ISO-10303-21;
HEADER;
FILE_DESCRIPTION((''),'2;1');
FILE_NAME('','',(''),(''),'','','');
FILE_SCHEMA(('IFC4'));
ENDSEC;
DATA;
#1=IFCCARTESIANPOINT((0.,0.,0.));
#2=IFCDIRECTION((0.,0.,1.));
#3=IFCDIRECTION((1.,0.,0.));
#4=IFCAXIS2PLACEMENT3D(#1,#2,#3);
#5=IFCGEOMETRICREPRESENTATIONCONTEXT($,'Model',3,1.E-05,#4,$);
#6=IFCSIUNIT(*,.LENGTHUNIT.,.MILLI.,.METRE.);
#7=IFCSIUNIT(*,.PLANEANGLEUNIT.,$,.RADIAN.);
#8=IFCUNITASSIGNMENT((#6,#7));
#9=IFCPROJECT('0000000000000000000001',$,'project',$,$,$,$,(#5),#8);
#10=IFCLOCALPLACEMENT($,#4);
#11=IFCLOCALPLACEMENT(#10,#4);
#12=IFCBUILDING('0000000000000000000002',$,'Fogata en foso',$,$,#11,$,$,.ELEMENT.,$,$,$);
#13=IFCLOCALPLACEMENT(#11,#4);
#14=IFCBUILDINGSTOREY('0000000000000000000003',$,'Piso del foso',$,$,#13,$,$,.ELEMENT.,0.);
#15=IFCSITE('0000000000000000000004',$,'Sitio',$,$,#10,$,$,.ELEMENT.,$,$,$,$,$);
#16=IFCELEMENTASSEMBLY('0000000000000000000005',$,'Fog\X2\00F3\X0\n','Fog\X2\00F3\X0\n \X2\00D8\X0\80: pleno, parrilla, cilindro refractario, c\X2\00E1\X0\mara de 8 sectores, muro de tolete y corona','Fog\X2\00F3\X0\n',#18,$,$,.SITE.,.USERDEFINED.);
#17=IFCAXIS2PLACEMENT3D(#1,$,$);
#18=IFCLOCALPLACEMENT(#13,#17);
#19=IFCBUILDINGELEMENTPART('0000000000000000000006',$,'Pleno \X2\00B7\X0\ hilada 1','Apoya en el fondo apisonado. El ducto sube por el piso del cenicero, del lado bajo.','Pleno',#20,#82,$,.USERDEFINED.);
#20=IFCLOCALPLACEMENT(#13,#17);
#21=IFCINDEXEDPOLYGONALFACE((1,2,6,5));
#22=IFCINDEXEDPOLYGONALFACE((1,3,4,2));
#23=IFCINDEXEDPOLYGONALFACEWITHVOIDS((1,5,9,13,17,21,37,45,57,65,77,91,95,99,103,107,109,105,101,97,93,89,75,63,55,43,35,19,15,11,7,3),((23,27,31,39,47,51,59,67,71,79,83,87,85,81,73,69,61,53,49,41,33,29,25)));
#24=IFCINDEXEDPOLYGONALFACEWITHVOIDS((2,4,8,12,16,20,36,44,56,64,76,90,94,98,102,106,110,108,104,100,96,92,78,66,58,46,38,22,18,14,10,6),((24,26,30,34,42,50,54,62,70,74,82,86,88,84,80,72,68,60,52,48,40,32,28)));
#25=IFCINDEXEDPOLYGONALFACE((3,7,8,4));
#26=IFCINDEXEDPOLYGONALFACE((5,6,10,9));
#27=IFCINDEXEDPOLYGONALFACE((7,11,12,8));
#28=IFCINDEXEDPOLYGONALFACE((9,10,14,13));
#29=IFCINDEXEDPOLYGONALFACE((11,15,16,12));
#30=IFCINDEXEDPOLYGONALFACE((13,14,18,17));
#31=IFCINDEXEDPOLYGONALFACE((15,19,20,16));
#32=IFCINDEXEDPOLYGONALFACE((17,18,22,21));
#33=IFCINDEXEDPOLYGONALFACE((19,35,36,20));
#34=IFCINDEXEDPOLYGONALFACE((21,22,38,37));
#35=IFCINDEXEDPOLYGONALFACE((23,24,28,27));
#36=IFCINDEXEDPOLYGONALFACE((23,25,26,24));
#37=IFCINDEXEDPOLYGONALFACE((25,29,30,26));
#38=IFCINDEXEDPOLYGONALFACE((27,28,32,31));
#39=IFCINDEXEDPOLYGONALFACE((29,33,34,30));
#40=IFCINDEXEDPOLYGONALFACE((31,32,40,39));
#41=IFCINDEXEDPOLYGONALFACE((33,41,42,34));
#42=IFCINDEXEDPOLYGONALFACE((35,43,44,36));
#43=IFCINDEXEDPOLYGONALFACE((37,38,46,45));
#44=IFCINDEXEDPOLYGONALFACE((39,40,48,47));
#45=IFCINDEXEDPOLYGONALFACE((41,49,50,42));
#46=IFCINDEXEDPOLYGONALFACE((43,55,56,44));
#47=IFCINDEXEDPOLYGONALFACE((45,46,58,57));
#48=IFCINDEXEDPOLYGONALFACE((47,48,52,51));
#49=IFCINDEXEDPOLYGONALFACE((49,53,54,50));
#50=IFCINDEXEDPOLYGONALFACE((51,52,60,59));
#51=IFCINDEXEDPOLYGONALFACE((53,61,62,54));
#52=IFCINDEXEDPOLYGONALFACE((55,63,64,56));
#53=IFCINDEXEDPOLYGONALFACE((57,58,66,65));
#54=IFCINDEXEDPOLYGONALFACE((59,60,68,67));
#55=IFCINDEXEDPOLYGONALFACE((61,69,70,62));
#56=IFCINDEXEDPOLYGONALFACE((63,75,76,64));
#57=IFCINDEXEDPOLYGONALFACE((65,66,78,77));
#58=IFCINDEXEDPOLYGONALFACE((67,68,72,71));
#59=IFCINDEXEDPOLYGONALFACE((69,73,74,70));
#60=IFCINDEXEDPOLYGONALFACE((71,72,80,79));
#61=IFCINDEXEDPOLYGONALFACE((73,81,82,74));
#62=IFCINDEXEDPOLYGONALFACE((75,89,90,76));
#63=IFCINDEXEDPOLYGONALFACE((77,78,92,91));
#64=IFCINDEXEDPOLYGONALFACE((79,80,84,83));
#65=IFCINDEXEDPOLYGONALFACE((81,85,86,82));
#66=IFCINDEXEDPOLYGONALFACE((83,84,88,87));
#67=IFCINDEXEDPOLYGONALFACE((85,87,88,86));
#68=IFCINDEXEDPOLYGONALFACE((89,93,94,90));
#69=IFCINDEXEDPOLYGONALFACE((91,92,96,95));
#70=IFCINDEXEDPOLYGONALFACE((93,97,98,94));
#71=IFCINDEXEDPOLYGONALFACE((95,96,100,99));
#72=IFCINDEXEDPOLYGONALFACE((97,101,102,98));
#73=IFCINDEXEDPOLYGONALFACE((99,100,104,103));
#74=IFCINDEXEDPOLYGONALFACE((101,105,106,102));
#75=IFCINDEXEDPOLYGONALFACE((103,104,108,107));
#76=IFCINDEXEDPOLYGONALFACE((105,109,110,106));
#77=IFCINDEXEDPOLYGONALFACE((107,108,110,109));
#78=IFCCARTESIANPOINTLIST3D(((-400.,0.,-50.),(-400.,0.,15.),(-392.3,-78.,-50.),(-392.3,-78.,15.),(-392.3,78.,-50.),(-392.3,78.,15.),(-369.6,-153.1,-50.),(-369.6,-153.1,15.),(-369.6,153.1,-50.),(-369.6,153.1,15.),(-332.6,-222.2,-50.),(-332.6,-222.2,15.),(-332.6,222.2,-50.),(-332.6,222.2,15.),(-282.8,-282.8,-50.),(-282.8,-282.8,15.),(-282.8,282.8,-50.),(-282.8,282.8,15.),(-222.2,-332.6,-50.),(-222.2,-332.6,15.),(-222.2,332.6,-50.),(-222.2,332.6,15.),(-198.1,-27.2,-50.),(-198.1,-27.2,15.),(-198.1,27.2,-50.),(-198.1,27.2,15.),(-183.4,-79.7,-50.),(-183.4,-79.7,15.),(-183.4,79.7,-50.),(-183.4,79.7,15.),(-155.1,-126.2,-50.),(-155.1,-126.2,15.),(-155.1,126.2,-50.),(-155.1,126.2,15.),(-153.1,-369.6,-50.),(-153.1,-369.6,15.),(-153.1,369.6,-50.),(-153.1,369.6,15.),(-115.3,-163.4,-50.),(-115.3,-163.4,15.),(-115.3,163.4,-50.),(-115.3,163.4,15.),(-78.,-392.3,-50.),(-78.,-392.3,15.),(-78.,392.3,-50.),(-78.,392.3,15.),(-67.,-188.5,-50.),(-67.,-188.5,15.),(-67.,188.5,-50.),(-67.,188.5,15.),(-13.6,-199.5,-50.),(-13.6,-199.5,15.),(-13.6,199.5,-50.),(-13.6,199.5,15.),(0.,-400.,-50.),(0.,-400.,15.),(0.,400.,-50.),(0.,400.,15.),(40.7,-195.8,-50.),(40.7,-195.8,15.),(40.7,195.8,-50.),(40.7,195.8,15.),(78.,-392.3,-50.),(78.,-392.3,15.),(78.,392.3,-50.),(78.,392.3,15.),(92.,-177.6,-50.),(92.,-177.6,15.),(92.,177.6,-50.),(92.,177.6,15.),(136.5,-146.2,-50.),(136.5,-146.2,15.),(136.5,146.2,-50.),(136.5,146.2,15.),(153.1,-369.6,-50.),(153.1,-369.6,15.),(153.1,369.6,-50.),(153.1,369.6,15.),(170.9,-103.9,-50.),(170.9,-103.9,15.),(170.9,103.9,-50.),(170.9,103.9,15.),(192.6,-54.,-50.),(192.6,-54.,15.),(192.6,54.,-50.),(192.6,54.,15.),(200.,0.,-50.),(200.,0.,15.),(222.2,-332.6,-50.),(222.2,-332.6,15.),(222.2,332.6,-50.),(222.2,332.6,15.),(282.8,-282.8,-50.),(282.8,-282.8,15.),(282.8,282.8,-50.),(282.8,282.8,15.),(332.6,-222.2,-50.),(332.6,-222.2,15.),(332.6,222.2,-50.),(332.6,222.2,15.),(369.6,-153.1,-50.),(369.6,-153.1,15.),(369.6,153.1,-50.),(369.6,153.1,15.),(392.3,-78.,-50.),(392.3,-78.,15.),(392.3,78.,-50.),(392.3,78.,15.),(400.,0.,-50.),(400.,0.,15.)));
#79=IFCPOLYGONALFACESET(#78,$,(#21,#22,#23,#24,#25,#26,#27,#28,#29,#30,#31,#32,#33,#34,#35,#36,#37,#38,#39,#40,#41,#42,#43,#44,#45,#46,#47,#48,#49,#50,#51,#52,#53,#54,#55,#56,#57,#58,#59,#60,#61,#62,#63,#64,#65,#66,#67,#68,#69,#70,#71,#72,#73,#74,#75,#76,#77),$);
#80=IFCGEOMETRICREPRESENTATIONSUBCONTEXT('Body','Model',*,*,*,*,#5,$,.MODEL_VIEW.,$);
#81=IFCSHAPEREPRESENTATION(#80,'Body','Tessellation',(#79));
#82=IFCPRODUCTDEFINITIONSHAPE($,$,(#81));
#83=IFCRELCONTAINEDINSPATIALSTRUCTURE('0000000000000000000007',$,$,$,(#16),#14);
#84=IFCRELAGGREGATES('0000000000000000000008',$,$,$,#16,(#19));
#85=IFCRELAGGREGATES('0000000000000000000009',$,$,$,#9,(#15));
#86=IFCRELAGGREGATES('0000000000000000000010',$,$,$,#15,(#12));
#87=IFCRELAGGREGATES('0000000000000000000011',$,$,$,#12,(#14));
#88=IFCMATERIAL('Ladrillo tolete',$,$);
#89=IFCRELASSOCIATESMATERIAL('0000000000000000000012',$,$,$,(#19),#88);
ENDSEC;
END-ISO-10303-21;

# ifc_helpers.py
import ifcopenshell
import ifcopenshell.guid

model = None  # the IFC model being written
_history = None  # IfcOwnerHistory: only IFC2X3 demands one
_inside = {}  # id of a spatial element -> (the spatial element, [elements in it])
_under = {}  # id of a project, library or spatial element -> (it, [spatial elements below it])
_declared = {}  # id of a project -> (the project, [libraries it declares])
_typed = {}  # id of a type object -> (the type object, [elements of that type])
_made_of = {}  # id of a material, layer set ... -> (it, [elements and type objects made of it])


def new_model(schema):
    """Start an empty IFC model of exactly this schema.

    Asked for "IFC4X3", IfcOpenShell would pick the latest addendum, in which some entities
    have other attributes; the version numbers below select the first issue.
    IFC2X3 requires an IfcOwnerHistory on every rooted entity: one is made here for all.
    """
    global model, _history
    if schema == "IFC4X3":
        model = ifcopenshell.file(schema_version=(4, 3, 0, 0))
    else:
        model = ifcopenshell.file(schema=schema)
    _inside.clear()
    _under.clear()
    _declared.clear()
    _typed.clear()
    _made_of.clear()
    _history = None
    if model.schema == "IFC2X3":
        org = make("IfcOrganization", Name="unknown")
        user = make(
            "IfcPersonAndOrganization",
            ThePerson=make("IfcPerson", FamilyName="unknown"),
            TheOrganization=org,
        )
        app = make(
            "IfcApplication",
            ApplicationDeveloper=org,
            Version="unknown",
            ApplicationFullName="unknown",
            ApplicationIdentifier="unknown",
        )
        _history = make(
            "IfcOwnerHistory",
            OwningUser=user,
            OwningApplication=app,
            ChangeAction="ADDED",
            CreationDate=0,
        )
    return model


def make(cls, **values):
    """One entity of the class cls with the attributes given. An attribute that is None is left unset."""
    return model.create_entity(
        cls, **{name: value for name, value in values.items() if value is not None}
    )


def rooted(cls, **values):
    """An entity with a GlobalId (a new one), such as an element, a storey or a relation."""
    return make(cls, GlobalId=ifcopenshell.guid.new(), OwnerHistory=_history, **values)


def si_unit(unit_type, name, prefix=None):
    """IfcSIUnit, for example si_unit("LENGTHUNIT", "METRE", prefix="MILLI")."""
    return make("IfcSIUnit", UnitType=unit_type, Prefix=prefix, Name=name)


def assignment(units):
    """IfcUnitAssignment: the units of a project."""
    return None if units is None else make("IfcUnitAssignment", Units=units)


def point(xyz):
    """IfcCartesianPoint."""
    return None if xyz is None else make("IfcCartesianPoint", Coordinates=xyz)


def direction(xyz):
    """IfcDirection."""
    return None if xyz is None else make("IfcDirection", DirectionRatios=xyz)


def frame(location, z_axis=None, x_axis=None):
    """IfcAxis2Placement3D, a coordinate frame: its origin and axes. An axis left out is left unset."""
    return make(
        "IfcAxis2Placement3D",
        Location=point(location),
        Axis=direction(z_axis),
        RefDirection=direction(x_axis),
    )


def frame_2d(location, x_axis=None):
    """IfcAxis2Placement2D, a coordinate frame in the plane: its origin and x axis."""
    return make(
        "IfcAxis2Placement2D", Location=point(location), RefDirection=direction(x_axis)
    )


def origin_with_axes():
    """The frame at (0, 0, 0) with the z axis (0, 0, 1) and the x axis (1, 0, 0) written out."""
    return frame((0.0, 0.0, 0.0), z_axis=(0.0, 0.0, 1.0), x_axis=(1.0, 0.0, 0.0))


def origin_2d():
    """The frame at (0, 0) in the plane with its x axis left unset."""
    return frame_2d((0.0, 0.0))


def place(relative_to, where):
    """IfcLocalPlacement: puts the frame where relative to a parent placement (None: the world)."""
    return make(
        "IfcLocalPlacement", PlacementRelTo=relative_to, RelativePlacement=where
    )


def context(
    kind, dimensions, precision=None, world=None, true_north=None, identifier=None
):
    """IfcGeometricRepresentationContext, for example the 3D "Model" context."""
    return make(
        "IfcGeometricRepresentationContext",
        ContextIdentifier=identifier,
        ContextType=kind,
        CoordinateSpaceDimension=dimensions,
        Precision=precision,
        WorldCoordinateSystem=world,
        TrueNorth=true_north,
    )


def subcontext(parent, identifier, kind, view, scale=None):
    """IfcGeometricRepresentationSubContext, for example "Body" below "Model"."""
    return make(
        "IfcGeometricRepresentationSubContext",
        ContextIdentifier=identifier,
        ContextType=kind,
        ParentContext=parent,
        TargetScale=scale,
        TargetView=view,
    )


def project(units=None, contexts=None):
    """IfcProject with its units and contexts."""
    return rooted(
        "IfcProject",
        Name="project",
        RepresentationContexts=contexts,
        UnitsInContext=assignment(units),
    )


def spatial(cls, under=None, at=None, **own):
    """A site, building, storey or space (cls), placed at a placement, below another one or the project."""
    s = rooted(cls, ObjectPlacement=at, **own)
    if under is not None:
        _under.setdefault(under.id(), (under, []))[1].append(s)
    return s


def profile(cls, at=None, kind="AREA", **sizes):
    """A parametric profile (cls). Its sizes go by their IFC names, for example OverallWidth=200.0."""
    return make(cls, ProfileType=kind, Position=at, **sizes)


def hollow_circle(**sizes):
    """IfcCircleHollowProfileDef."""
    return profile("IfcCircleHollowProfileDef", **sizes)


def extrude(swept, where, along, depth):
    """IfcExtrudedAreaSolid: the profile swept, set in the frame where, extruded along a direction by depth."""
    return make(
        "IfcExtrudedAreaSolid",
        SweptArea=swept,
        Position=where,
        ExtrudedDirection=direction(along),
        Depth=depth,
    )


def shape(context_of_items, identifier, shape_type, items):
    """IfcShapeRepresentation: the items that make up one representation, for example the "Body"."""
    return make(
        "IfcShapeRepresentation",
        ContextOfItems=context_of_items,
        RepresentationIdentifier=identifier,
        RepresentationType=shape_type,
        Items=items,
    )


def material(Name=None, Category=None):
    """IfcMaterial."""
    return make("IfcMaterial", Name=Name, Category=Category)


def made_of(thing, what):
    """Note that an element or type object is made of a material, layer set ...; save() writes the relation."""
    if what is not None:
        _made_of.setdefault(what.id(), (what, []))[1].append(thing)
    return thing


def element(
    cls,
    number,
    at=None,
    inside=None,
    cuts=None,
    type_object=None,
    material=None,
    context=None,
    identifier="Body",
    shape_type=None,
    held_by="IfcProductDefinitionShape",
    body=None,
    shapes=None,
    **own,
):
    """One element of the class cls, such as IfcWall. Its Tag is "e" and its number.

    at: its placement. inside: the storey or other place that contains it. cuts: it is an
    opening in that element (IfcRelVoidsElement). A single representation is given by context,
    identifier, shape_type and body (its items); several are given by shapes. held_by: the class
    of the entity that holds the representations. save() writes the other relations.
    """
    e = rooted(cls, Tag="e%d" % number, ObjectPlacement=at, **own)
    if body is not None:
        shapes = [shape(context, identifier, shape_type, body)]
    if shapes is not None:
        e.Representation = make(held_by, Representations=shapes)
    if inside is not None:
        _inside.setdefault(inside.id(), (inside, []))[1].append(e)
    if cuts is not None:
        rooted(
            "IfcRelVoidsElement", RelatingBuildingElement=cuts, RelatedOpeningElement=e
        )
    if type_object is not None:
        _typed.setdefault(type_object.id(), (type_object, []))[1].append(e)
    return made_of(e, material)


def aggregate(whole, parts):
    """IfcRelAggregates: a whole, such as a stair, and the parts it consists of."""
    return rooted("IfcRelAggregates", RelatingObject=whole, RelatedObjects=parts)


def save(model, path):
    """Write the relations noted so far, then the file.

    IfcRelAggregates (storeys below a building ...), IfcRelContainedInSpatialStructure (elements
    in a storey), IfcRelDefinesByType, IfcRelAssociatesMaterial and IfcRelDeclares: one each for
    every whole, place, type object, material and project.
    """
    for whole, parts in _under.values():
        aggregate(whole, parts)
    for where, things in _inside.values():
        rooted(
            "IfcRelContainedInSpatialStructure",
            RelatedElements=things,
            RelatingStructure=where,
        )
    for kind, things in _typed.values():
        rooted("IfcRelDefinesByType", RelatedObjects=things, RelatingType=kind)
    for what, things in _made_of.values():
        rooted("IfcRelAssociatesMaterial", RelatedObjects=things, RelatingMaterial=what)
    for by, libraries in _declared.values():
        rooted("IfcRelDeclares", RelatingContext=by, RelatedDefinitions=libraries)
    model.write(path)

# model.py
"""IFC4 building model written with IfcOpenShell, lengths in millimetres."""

from ifc_helpers import new_model, si_unit, frame, origin_with_axes, origin_2d, place, context, subcontext, project, spatial, hollow_circle, extrude, material, element, aggregate, save


model = new_model("IFC4")

# Units and contexts
model_context = context("Model", 3, precision=1e-05, world=origin_with_axes())
body_context = subcontext(model_context, "Body", "Model", "MODEL_VIEW")
ifc_project = project(units=[si_unit("LENGTHUNIT", "METRE", prefix="MILLI"), si_unit("PLANEANGLEUNIT", "RADIAN")], contexts=[model_context])

# Site, building, storey
site_placement = place(None, origin_with_axes())
site = spatial("IfcSite", under=ifc_project, at=site_placement, Name="Sitio", CompositionType="ELEMENT")
building_placement = place(site_placement, origin_with_axes())
building = spatial("IfcBuilding", under=site, at=building_placement, Name="Fogata en foso", CompositionType="ELEMENT")
storey_placement = place(building_placement, origin_with_axes())
storey = spatial("IfcBuildingStorey", under=building, at=storey_placement, Name="Piso del foso", CompositionType="ELEMENT", Elevation=0.0)

# Shared definitions
ifc_material_1 = material(Name="Ladrillo tolete")

# Element assembly, building element part
assembly_1_placement = place(storey_placement, origin_with_axes())
assembly_1 = element("IfcElementAssembly", 1, at=assembly_1_placement, inside=storey, Name="Fogón", Description="Fogón Ø80: pleno, parrilla, cilindro refractario, cámara de 8 sectores, muro de tolete y corona", ObjectType="Fogón", AssemblyPlace="SITE", PredefinedType="USERDEFINED")
building_element_part_1_placement = place(storey_placement, frame((0.0, 0.0, -50.0), z_axis=(0.0, 0.0, 1.0), x_axis=(1.0, 0.0, 0.0)))
building_element_part_1 = element("IfcBuildingElementPart", 2, at=building_element_part_1_placement, material=ifc_material_1, Name="Pleno · hilada 1", Description="Apoya en el fondo apisonado. El ducto sube por el piso del cenicero, del lado bajo.", ObjectType="Pleno", PredefinedType="USERDEFINED", context=body_context, shape_type="SweptSolid", body=[
    extrude(hollow_circle(Radius=400.0, WallThickness=200.0, at=origin_2d()), origin_with_axes(), (0.0, 0.0, 1.0), 65.0),
])
aggregate(assembly_1, [building_element_part_1])

save(model, "model.ifc")
